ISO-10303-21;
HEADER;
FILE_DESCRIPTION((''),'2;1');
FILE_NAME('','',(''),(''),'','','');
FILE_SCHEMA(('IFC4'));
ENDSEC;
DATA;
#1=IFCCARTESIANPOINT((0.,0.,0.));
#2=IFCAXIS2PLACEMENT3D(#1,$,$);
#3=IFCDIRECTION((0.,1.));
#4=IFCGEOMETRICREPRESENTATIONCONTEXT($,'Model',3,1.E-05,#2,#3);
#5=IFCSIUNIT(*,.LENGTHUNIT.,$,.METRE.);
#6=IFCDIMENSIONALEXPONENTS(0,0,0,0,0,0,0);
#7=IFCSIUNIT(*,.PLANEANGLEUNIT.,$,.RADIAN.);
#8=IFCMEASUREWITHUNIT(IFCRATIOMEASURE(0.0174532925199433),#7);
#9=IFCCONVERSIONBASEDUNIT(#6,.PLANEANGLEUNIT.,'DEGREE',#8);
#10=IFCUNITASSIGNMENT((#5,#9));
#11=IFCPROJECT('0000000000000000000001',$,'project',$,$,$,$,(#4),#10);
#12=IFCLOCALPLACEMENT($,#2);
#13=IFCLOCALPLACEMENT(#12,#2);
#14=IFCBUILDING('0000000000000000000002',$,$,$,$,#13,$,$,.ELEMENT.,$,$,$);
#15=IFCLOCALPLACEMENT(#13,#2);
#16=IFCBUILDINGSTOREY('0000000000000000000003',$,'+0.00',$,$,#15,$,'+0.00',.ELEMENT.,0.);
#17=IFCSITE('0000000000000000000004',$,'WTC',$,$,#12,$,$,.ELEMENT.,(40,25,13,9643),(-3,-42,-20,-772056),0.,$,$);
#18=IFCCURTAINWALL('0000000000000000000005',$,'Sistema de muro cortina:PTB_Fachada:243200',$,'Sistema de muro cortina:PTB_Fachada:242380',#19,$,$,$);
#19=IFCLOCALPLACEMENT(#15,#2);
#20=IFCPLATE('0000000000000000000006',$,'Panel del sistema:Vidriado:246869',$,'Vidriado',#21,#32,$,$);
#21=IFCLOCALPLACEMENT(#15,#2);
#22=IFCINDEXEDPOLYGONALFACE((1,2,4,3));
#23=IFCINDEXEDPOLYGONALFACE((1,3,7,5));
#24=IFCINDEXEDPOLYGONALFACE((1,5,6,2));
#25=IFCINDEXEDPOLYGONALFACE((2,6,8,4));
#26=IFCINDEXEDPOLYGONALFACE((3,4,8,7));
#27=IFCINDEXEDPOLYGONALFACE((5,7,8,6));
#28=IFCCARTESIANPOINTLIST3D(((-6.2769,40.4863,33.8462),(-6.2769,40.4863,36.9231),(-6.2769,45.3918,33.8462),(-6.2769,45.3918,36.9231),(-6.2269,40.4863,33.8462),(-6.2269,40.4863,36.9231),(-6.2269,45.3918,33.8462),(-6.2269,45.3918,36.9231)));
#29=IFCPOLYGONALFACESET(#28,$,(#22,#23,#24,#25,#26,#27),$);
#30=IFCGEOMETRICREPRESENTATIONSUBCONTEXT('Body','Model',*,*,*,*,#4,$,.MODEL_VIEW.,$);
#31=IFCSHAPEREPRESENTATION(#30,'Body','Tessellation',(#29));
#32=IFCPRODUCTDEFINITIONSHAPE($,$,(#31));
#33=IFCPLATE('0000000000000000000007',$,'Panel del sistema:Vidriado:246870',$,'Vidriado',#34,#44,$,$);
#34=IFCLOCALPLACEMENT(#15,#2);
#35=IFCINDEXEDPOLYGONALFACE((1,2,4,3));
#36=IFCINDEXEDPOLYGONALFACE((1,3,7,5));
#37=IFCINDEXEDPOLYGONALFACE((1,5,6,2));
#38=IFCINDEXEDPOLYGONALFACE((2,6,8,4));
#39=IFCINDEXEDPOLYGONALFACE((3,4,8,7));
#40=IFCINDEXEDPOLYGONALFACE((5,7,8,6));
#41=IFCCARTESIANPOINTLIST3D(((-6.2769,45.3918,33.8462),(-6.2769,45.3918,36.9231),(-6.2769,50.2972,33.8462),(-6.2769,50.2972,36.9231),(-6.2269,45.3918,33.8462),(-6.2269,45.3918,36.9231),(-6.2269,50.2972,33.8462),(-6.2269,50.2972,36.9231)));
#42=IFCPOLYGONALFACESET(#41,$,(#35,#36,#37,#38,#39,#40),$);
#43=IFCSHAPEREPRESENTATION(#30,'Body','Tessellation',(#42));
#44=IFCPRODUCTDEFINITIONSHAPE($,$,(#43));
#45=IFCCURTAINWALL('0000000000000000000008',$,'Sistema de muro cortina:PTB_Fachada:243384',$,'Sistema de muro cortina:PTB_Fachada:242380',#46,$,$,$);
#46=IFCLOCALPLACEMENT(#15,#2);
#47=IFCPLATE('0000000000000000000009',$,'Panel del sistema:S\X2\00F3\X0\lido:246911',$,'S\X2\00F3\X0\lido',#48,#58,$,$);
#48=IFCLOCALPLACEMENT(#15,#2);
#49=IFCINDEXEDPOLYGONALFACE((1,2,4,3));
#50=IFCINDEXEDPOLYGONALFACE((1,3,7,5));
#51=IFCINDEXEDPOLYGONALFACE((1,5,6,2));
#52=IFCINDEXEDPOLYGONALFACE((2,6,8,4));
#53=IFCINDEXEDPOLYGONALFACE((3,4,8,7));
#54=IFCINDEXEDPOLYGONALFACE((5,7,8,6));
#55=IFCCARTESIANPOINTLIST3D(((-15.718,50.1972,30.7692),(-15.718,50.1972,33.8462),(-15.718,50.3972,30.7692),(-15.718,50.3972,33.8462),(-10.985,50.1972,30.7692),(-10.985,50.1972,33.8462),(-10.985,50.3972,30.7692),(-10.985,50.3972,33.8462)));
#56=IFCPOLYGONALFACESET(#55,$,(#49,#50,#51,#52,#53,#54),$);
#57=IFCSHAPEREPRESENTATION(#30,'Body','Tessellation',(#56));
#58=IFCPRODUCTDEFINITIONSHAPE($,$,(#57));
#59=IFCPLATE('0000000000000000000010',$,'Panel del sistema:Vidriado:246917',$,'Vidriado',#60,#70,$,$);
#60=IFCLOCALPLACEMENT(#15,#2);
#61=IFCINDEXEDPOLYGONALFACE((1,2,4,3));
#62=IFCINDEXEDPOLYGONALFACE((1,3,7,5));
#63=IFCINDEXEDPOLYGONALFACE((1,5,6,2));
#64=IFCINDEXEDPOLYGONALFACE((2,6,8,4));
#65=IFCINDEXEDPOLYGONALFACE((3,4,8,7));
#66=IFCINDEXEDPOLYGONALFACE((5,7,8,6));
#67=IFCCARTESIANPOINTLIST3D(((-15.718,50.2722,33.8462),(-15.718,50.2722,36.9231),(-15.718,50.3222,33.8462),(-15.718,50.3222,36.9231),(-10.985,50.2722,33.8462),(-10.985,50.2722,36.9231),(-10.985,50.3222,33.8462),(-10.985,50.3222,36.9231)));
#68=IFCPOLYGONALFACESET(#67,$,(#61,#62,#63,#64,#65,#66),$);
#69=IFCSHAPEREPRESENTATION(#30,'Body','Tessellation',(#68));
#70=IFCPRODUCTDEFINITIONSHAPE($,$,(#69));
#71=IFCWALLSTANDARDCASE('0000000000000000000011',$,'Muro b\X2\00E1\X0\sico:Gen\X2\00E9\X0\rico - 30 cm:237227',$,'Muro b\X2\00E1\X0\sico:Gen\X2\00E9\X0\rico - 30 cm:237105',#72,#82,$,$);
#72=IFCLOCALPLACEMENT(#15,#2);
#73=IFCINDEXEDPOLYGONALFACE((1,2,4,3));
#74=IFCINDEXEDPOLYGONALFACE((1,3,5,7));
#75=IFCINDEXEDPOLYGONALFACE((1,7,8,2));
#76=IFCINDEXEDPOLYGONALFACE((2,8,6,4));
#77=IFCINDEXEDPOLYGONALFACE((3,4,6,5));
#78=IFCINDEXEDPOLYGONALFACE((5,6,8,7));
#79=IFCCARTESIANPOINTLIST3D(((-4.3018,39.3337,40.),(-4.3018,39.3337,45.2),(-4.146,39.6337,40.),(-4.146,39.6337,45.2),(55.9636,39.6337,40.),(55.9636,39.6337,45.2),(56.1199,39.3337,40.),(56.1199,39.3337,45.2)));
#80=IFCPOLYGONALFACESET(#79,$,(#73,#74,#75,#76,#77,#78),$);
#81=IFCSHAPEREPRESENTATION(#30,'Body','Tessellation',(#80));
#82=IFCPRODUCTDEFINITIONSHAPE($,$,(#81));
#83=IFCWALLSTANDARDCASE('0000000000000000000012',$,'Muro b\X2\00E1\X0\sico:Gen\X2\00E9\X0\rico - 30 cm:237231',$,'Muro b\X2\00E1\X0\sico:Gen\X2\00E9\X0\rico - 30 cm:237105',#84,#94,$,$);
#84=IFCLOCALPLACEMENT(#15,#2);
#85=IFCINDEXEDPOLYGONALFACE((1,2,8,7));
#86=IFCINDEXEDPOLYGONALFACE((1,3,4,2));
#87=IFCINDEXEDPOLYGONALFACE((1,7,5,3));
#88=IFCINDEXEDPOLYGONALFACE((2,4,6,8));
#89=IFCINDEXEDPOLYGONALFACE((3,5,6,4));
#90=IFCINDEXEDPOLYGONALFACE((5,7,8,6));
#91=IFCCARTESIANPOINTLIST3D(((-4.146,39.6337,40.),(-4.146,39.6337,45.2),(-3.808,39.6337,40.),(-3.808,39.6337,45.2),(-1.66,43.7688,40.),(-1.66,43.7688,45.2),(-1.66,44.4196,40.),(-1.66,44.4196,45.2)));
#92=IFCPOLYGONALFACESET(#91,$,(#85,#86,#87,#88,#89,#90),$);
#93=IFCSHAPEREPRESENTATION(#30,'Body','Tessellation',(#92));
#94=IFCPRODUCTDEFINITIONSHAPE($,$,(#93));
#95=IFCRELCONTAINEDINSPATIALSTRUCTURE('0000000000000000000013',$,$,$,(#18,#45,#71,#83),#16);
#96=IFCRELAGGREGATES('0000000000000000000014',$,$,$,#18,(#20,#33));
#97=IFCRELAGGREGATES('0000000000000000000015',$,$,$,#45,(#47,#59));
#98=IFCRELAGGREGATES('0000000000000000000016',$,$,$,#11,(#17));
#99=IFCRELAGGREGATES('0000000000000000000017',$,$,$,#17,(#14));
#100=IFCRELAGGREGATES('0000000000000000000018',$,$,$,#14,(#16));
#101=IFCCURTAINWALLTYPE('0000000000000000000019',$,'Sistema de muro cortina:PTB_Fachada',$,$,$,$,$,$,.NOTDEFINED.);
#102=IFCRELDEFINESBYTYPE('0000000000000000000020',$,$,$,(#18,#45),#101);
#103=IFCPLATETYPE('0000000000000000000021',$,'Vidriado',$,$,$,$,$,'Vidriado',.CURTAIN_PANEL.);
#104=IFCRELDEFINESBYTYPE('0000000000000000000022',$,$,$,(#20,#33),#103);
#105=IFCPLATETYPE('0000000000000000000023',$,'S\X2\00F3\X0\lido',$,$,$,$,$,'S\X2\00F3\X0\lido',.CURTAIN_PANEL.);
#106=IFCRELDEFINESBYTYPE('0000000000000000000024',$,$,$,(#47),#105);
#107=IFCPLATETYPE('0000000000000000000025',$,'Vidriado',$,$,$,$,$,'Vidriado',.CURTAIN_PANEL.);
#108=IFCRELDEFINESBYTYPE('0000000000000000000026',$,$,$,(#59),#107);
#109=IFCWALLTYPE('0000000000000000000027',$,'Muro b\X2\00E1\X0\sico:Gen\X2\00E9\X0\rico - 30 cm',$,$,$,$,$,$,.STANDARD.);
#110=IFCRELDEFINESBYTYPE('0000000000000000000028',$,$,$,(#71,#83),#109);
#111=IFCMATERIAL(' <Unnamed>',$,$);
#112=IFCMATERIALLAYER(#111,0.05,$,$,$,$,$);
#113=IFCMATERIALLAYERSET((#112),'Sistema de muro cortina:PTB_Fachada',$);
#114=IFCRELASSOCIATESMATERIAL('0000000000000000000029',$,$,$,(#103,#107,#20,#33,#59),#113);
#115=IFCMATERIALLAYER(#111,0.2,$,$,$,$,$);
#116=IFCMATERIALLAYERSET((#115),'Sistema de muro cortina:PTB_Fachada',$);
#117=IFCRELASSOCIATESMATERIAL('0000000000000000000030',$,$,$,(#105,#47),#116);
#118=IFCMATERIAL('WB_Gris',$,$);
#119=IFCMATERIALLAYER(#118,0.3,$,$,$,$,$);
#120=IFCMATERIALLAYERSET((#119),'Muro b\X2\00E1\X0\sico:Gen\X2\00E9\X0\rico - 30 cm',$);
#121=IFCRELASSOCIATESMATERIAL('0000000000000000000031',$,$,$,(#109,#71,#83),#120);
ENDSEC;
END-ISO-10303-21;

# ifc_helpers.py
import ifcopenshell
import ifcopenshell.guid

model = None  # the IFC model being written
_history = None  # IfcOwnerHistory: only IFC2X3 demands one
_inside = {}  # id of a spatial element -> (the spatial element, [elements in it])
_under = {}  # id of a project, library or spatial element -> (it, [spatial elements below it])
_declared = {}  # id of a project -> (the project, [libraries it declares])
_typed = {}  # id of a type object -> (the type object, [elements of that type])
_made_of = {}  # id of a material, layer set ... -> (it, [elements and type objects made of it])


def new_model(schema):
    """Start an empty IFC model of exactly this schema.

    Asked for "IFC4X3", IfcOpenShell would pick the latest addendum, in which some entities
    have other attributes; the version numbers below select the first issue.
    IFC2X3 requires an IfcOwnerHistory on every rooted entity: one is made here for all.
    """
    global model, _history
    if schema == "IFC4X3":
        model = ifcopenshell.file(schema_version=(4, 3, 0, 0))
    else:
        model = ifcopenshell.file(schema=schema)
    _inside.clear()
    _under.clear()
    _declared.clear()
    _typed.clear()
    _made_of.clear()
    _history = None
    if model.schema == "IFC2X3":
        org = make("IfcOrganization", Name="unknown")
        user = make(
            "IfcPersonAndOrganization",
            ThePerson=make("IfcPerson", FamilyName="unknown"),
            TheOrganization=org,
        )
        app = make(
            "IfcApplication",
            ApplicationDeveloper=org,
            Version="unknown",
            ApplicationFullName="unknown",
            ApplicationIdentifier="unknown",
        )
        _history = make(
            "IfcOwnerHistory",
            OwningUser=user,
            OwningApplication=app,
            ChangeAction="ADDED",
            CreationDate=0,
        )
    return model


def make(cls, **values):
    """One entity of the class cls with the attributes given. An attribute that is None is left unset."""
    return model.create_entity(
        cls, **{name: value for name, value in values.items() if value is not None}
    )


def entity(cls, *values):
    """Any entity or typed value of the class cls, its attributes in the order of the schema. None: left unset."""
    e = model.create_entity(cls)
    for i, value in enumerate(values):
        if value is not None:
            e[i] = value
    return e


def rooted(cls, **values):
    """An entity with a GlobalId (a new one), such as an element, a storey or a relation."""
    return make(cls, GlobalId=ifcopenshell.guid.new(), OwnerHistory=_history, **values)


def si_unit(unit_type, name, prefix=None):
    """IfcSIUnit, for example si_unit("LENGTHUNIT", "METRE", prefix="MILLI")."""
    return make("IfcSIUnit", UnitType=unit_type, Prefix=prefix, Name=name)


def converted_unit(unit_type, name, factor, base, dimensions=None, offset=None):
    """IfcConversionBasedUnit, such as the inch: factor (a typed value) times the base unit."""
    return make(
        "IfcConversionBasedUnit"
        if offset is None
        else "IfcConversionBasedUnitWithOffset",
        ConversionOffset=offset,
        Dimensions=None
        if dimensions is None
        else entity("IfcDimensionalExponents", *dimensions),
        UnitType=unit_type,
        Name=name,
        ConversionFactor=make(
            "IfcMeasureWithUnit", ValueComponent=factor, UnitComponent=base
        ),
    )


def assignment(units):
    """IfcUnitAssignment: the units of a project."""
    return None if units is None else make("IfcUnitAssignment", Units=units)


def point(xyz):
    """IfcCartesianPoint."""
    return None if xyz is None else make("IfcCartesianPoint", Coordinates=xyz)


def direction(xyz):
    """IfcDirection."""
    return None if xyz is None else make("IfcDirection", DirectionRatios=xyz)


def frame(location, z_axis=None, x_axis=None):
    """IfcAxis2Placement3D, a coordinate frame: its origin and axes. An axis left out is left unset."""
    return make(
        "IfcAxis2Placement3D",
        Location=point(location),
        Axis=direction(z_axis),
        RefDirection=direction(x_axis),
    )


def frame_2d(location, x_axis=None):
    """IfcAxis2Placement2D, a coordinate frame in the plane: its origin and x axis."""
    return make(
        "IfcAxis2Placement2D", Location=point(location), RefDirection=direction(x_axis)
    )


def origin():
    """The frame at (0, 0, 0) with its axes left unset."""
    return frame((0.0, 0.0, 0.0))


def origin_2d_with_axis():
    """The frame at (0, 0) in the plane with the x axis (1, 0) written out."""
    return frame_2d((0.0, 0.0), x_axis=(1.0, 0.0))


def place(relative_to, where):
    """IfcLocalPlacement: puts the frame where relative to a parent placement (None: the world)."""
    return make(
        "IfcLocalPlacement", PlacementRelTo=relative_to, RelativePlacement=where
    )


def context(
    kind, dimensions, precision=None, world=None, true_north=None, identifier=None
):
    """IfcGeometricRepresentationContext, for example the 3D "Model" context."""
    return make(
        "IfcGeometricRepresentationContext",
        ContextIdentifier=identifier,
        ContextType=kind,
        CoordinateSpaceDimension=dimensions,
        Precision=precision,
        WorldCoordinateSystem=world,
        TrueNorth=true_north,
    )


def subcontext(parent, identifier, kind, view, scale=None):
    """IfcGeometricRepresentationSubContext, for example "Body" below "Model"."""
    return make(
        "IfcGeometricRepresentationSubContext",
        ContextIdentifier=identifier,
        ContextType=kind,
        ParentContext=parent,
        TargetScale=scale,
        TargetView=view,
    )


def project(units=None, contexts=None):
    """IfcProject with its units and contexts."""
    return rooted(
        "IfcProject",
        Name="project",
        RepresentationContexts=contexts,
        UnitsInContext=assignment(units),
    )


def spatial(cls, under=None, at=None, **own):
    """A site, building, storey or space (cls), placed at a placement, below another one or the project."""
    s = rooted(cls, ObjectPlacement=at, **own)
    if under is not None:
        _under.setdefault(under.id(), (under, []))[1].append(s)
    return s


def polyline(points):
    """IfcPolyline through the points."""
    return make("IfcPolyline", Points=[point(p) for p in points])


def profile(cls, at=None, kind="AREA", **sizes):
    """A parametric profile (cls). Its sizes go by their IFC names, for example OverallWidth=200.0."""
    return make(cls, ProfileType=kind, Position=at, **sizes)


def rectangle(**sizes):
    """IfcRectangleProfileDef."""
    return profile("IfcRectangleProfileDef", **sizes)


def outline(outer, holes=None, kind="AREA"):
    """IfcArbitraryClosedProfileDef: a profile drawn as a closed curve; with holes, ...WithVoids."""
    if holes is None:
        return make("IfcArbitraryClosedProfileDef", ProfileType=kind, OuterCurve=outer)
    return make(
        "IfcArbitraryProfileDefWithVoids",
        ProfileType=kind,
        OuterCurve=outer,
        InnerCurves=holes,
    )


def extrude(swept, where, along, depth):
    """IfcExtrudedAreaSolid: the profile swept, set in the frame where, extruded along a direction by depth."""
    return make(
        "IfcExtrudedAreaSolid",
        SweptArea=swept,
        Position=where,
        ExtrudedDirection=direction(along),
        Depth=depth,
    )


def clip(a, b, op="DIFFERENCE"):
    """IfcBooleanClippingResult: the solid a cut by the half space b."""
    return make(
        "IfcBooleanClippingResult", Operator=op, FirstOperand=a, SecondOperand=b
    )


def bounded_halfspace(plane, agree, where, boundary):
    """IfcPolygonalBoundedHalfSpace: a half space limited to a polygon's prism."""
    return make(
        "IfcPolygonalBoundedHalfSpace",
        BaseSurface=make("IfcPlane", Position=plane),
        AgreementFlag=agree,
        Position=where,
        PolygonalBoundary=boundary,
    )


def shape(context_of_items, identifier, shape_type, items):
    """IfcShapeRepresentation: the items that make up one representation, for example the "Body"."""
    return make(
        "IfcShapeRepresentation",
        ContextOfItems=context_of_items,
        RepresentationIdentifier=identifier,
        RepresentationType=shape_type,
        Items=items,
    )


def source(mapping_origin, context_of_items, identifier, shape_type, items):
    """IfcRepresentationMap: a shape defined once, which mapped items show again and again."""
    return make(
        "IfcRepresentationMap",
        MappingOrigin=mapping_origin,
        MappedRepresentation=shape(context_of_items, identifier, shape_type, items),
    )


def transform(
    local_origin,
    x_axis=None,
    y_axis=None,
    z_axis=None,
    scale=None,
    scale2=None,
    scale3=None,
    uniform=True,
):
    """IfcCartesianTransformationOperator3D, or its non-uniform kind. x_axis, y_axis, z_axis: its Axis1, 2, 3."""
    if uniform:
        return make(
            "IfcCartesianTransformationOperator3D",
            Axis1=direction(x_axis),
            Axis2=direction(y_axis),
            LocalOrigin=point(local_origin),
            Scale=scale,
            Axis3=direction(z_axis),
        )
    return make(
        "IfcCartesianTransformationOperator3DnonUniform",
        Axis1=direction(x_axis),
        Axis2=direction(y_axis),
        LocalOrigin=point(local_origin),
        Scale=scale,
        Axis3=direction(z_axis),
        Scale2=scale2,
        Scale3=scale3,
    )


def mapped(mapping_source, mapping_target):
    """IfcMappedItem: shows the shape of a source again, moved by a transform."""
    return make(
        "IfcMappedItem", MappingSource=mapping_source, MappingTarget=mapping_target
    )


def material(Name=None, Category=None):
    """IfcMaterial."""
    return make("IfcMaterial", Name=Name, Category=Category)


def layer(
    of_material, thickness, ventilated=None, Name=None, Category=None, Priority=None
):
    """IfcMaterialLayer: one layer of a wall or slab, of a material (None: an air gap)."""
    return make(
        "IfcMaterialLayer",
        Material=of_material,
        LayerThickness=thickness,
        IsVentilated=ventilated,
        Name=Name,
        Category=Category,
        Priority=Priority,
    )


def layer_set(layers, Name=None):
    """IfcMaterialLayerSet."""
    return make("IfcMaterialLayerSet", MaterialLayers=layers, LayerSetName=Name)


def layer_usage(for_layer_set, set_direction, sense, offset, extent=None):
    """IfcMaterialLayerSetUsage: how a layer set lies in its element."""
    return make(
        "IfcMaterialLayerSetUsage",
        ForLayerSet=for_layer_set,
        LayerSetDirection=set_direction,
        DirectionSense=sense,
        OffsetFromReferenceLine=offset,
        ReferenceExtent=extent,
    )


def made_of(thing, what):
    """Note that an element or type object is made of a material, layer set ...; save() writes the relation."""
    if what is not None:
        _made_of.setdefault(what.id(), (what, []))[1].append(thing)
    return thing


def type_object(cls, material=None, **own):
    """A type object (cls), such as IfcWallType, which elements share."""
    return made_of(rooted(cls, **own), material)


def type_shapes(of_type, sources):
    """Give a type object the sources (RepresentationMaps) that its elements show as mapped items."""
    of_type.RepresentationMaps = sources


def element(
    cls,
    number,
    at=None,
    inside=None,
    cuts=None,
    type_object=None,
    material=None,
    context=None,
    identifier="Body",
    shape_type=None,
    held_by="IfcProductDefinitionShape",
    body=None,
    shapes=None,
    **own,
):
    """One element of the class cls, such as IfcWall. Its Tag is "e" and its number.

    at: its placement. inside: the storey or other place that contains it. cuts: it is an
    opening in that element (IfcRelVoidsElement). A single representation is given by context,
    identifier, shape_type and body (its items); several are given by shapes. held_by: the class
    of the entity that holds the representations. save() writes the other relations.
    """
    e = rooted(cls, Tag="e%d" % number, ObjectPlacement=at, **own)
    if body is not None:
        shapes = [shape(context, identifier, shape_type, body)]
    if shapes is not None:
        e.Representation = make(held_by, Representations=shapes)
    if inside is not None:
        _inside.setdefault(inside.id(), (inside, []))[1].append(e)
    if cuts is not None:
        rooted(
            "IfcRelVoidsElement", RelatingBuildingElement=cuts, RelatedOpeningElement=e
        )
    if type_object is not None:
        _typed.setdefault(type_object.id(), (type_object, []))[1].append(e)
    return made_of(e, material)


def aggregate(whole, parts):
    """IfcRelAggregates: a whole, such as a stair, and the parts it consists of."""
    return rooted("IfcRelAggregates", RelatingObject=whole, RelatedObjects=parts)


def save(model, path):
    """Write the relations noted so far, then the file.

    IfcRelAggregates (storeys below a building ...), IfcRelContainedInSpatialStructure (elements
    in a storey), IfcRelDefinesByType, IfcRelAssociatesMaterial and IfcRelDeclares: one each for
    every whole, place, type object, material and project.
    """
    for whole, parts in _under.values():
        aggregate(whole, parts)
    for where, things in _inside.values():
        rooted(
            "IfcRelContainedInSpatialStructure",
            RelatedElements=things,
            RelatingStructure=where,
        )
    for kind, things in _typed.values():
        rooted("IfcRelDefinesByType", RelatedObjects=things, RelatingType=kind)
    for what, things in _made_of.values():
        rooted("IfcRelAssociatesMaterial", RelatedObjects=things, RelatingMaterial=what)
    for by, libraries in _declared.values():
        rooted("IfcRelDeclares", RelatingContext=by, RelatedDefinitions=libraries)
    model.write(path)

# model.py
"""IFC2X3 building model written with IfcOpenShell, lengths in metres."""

from ifc_helpers import new_model, entity, si_unit, converted_unit, direction, frame, frame_2d, origin, origin_2d_with_axis, place, context, subcontext, project, spatial, polyline, rectangle, outline, extrude, clip, bounded_halfspace, source, transform, mapped, material, layer, layer_set, layer_usage, type_object, type_shapes, element, aggregate, save


model = new_model("IFC2X3")

# Units and contexts
model_context = context("Model", 3, precision=1e-05, world=origin(), true_north=direction((0.0, 1.0)))
body_context = subcontext(model_context, "Body", "Model", "MODEL_VIEW")
ifc_project = project(units=[si_unit("LENGTHUNIT", "METRE"), converted_unit("PLANEANGLEUNIT", "DEGREE", entity("IfcRatioMeasure", 0.0174532925199433), si_unit("PLANEANGLEUNIT", "RADIAN"), dimensions=[0, 0, 0, 0, 0, 0, 0])], contexts=[model_context])

# Site, building, storey
site_placement = place(None, origin())
site = spatial("IfcSite", under=ifc_project, at=site_placement, Name="WTC", CompositionType="ELEMENT", RefLatitude=(40, 25, 13, 9643), RefLongitude=(-3, -42, -20, -772056), RefElevation=0.0)
building_placement = place(site_placement, origin())
building = spatial("IfcBuilding", under=site, at=building_placement, CompositionType="ELEMENT")
storey_placement = place(building_placement, origin())
storey = spatial("IfcBuildingStorey", under=building, at=storey_placement, Name="+0.00", LongName="+0.00", CompositionType="ELEMENT", Elevation=0.0)

# Curtain walls, plates
curtain_wall_type = type_object("IfcCurtainWallType", Name="Sistema de muro cortina:PTB_Fachada", PredefinedType="NOTDEFINED")
curtain_wall_1_placement = place(storey_placement, origin())
curtain_wall_1 = element("IfcCurtainWall", 1, at=curtain_wall_1_placement, inside=storey, type_object=curtain_wall_type, Name="Sistema de muro cortina:PTB_Fachada:243200", ObjectType="Sistema de muro cortina:PTB_Fachada:242380")
ifc_material_1 = material(Name=" <Unnamed>")
ifc_layer_1 = layer(ifc_material_1, 0.2)
ifc_layer_set_1 = layer_set([ifc_layer_1], Name="Sistema de muro cortina:PTB_Fachada")
ifc_layer_2 = layer(ifc_material_1, 0.05)
ifc_layer_set_2 = layer_set([ifc_layer_2], Name="Sistema de muro cortina:PTB_Fachada")
plate_type_1 = type_object("IfcPlateType", Name="Vidriado", ElementType="Vidriado", PredefinedType="CURTAIN_PANEL", material=ifc_layer_set_2)
shared_shape_1 = source(origin(), body_context, "Body", "SweptSolid", [
    extrude(rectangle(XDim=0.05, YDim=4.9055, at=origin_2d_with_axis()), frame((0.0, 0.0, 0.0), z_axis=(0.0, 0.0, 1.0), x_axis=(0.0, 1.0, 0.0)), (0.0, 0.0, 1.0), 3.0769),
])
type_shapes(plate_type_1, [shared_shape_1])
ifc_layer_usage_1 = layer_usage(ifc_layer_set_2, "AXIS3", "POSITIVE", 0.0)
plate_1_placement = place(curtain_wall_1_placement, frame((-6.2519, 42.939, 33.8462), z_axis=(0.0, 0.0, 1.0), x_axis=(0.0, 1.0, 0.0)))
plate_1 = element("IfcPlate", 2, at=plate_1_placement, type_object=plate_type_1, material=ifc_layer_usage_1, Name="Panel del sistema:Vidriado:246869", ObjectType="Vidriado", context=body_context, shape_type="MappedRepresentation", body=[
    mapped(shared_shape_1, transform((0.0, 0.0, 0.0), scale=1.0)),
])
ifc_layer_usage_2 = layer_usage(ifc_layer_set_2, "AXIS3", "POSITIVE", 0.0)
plate_2_placement = place(curtain_wall_1_placement, frame((-6.2519, 47.8445, 33.8462), z_axis=(0.0, 0.0, 1.0), x_axis=(0.0, 1.0, 0.0)))
plate_2 = element("IfcPlate", 3, at=plate_2_placement, type_object=plate_type_1, material=ifc_layer_usage_2, Name="Panel del sistema:Vidriado:246870", ObjectType="Vidriado", context=body_context, shape_type="MappedRepresentation", body=[
    mapped(shared_shape_1, transform((0.0, 0.0, 0.0), scale=1.0)),
])
aggregate(curtain_wall_1, [plate_1, plate_2])
curtain_wall_2_placement = place(storey_placement, origin())
curtain_wall_2 = element("IfcCurtainWall", 4, at=curtain_wall_2_placement, inside=storey, type_object=curtain_wall_type, Name="Sistema de muro cortina:PTB_Fachada:243384", ObjectType="Sistema de muro cortina:PTB_Fachada:242380")
ifc_layer_usage_3 = layer_usage(ifc_layer_set_1, "AXIS3", "POSITIVE", 0.0)
plate_type_2 = type_object("IfcPlateType", Name="Sólido", ElementType="Sólido", PredefinedType="CURTAIN_PANEL", material=ifc_layer_set_1)
shared_shape_2 = source(origin(), body_context, "Body", "SweptSolid", [
    extrude(rectangle(XDim=0.2, YDim=4.7331, at=frame_2d((0.0, 0.0), x_axis=(1.0, 0.0))), frame((0.0, 0.0, 0.0), z_axis=(0.0, 0.0, 1.0), x_axis=(0.0, 1.0, 0.0)), (0.0, 0.0, 1.0), 3.0769),
])
type_shapes(plate_type_2, [shared_shape_2])
plate_3_placement = place(curtain_wall_2_placement, frame((-13.3515, 50.2972, 30.7692), z_axis=(0.0, 0.0, 1.0), x_axis=(-1.0, 0.0, 0.0)))
plate_3 = element("IfcPlate", 5, at=plate_3_placement, type_object=plate_type_2, material=ifc_layer_usage_3, Name="Panel del sistema:Sólido:246911", ObjectType="Sólido", context=body_context, shape_type="MappedRepresentation", body=[
    mapped(shared_shape_2, transform((0.0, 0.0, 0.0), scale=1.0)),
])
ifc_layer_usage_4 = layer_usage(ifc_layer_set_2, "AXIS3", "POSITIVE", 0.0)
plate_type_3 = type_object("IfcPlateType", Name="Vidriado", ElementType="Vidriado", PredefinedType="CURTAIN_PANEL", material=ifc_layer_set_2)
shared_shape_3 = source(origin(), body_context, "Body", "SweptSolid", [
    extrude(rectangle(XDim=0.05, YDim=4.7331, at=origin_2d_with_axis()), frame((0.0, 0.0, 0.0), z_axis=(0.0, 0.0, 1.0), x_axis=(0.0, 1.0, 0.0)), (0.0, 0.0, 1.0), 3.0769),
])
type_shapes(plate_type_3, [shared_shape_3])
plate_4_placement = place(curtain_wall_2_placement, frame((-13.3515, 50.2972, 33.8462), z_axis=(0.0, 0.0, 1.0), x_axis=(-1.0, 0.0, 0.0)))
plate_4 = element("IfcPlate", 6, at=plate_4_placement, type_object=plate_type_3, material=ifc_layer_usage_4, Name="Panel del sistema:Vidriado:246917", ObjectType="Vidriado", context=body_context, shape_type="MappedRepresentation", body=[
    mapped(shared_shape_3, transform((0.0, 0.0, 0.0), scale=1.0)),
])
aggregate(curtain_wall_2, [plate_3, plate_4])

# Walls
ifc_material_2 = material(Name="WB_Gris")
ifc_layer_3 = layer(ifc_material_2, 0.3)
ifc_layer_set_3 = layer_set([ifc_layer_3], Name="Muro básico:Genérico - 30 cm")
ifc_layer_usage_5 = layer_usage(ifc_layer_set_3, "AXIS2", "POSITIVE", -0.15)
wall_type = type_object("IfcWallType", Name="Muro básico:Genérico - 30 cm", PredefinedType="STANDARD", material=ifc_layer_set_3)
wall_1_placement = place(storey_placement, frame((-4.3018, 39.4837, 40.0)))
element("IfcWallStandardCase", 7, at=wall_1_placement, inside=storey, type_object=wall_type, material=ifc_layer_usage_5, Name="Muro básico:Genérico - 30 cm:237227", ObjectType="Muro básico:Genérico - 30 cm:237105", context=body_context, shape_type="Clipping", body=[
    clip(extrude(outline(polyline([(60.4217, -0.15), (60.2654, 0.15), (0.4939, 0.15), (0.1558, 0.15), (0.0, -0.15), (60.4217, -0.15)])), origin(), (0.0, 0.0, 1.0), 5.2), bounded_halfspace(frame((0.0, -0.15, 5.2)), False, frame((0.0, -0.15, 5.2)), polyline([(0.0, 0.0), (60.4217, 0.0), (60.2654, 0.3), (0.1558, 0.3), (0.0, 0.0)]))),
])
ifc_layer_usage_6 = layer_usage(ifc_layer_set_3, "AXIS2", "POSITIVE", -0.15)
wall_2_placement = place(storey_placement, frame((-1.5269, 44.3504, 40.0), z_axis=(0.0, 0.0, 1.0), x_axis=(-0.46096, -0.887421, 0.0)))
element("IfcWallStandardCase", 8, at=wall_2_placement, inside=storey, type_object=wall_type, material=ifc_layer_usage_6, Name="Muro básico:Genérico - 30 cm:237231", ObjectType="Muro básico:Genérico - 30 cm:237105", context=body_context, shape_type="Clipping", body=[
    clip(extrude(outline(polyline([(5.393, -0.15), (5.2372, 0.15), (0.5775, 0.15), (0.0, -0.15), (5.393, -0.15)])), origin(), (0.0, 0.0, 1.0), 5.2), bounded_halfspace(frame((0.0, -0.15, 5.2), z_axis=(0.0, 0.0, 1.0), x_axis=(-0.46096, 0.887421, 0.0)), False, frame((0.0, -0.15, 5.2), z_axis=(0.0, 0.0, 1.0), x_axis=(-0.46096, 0.887421, 0.0)), polyline([(0.0, 0.0), (-2.486, -4.7859), (-2.1479, -4.7859), (0.0, -0.6508), (0.0, 0.0)]))),
])

save(model, "model.ifc")
